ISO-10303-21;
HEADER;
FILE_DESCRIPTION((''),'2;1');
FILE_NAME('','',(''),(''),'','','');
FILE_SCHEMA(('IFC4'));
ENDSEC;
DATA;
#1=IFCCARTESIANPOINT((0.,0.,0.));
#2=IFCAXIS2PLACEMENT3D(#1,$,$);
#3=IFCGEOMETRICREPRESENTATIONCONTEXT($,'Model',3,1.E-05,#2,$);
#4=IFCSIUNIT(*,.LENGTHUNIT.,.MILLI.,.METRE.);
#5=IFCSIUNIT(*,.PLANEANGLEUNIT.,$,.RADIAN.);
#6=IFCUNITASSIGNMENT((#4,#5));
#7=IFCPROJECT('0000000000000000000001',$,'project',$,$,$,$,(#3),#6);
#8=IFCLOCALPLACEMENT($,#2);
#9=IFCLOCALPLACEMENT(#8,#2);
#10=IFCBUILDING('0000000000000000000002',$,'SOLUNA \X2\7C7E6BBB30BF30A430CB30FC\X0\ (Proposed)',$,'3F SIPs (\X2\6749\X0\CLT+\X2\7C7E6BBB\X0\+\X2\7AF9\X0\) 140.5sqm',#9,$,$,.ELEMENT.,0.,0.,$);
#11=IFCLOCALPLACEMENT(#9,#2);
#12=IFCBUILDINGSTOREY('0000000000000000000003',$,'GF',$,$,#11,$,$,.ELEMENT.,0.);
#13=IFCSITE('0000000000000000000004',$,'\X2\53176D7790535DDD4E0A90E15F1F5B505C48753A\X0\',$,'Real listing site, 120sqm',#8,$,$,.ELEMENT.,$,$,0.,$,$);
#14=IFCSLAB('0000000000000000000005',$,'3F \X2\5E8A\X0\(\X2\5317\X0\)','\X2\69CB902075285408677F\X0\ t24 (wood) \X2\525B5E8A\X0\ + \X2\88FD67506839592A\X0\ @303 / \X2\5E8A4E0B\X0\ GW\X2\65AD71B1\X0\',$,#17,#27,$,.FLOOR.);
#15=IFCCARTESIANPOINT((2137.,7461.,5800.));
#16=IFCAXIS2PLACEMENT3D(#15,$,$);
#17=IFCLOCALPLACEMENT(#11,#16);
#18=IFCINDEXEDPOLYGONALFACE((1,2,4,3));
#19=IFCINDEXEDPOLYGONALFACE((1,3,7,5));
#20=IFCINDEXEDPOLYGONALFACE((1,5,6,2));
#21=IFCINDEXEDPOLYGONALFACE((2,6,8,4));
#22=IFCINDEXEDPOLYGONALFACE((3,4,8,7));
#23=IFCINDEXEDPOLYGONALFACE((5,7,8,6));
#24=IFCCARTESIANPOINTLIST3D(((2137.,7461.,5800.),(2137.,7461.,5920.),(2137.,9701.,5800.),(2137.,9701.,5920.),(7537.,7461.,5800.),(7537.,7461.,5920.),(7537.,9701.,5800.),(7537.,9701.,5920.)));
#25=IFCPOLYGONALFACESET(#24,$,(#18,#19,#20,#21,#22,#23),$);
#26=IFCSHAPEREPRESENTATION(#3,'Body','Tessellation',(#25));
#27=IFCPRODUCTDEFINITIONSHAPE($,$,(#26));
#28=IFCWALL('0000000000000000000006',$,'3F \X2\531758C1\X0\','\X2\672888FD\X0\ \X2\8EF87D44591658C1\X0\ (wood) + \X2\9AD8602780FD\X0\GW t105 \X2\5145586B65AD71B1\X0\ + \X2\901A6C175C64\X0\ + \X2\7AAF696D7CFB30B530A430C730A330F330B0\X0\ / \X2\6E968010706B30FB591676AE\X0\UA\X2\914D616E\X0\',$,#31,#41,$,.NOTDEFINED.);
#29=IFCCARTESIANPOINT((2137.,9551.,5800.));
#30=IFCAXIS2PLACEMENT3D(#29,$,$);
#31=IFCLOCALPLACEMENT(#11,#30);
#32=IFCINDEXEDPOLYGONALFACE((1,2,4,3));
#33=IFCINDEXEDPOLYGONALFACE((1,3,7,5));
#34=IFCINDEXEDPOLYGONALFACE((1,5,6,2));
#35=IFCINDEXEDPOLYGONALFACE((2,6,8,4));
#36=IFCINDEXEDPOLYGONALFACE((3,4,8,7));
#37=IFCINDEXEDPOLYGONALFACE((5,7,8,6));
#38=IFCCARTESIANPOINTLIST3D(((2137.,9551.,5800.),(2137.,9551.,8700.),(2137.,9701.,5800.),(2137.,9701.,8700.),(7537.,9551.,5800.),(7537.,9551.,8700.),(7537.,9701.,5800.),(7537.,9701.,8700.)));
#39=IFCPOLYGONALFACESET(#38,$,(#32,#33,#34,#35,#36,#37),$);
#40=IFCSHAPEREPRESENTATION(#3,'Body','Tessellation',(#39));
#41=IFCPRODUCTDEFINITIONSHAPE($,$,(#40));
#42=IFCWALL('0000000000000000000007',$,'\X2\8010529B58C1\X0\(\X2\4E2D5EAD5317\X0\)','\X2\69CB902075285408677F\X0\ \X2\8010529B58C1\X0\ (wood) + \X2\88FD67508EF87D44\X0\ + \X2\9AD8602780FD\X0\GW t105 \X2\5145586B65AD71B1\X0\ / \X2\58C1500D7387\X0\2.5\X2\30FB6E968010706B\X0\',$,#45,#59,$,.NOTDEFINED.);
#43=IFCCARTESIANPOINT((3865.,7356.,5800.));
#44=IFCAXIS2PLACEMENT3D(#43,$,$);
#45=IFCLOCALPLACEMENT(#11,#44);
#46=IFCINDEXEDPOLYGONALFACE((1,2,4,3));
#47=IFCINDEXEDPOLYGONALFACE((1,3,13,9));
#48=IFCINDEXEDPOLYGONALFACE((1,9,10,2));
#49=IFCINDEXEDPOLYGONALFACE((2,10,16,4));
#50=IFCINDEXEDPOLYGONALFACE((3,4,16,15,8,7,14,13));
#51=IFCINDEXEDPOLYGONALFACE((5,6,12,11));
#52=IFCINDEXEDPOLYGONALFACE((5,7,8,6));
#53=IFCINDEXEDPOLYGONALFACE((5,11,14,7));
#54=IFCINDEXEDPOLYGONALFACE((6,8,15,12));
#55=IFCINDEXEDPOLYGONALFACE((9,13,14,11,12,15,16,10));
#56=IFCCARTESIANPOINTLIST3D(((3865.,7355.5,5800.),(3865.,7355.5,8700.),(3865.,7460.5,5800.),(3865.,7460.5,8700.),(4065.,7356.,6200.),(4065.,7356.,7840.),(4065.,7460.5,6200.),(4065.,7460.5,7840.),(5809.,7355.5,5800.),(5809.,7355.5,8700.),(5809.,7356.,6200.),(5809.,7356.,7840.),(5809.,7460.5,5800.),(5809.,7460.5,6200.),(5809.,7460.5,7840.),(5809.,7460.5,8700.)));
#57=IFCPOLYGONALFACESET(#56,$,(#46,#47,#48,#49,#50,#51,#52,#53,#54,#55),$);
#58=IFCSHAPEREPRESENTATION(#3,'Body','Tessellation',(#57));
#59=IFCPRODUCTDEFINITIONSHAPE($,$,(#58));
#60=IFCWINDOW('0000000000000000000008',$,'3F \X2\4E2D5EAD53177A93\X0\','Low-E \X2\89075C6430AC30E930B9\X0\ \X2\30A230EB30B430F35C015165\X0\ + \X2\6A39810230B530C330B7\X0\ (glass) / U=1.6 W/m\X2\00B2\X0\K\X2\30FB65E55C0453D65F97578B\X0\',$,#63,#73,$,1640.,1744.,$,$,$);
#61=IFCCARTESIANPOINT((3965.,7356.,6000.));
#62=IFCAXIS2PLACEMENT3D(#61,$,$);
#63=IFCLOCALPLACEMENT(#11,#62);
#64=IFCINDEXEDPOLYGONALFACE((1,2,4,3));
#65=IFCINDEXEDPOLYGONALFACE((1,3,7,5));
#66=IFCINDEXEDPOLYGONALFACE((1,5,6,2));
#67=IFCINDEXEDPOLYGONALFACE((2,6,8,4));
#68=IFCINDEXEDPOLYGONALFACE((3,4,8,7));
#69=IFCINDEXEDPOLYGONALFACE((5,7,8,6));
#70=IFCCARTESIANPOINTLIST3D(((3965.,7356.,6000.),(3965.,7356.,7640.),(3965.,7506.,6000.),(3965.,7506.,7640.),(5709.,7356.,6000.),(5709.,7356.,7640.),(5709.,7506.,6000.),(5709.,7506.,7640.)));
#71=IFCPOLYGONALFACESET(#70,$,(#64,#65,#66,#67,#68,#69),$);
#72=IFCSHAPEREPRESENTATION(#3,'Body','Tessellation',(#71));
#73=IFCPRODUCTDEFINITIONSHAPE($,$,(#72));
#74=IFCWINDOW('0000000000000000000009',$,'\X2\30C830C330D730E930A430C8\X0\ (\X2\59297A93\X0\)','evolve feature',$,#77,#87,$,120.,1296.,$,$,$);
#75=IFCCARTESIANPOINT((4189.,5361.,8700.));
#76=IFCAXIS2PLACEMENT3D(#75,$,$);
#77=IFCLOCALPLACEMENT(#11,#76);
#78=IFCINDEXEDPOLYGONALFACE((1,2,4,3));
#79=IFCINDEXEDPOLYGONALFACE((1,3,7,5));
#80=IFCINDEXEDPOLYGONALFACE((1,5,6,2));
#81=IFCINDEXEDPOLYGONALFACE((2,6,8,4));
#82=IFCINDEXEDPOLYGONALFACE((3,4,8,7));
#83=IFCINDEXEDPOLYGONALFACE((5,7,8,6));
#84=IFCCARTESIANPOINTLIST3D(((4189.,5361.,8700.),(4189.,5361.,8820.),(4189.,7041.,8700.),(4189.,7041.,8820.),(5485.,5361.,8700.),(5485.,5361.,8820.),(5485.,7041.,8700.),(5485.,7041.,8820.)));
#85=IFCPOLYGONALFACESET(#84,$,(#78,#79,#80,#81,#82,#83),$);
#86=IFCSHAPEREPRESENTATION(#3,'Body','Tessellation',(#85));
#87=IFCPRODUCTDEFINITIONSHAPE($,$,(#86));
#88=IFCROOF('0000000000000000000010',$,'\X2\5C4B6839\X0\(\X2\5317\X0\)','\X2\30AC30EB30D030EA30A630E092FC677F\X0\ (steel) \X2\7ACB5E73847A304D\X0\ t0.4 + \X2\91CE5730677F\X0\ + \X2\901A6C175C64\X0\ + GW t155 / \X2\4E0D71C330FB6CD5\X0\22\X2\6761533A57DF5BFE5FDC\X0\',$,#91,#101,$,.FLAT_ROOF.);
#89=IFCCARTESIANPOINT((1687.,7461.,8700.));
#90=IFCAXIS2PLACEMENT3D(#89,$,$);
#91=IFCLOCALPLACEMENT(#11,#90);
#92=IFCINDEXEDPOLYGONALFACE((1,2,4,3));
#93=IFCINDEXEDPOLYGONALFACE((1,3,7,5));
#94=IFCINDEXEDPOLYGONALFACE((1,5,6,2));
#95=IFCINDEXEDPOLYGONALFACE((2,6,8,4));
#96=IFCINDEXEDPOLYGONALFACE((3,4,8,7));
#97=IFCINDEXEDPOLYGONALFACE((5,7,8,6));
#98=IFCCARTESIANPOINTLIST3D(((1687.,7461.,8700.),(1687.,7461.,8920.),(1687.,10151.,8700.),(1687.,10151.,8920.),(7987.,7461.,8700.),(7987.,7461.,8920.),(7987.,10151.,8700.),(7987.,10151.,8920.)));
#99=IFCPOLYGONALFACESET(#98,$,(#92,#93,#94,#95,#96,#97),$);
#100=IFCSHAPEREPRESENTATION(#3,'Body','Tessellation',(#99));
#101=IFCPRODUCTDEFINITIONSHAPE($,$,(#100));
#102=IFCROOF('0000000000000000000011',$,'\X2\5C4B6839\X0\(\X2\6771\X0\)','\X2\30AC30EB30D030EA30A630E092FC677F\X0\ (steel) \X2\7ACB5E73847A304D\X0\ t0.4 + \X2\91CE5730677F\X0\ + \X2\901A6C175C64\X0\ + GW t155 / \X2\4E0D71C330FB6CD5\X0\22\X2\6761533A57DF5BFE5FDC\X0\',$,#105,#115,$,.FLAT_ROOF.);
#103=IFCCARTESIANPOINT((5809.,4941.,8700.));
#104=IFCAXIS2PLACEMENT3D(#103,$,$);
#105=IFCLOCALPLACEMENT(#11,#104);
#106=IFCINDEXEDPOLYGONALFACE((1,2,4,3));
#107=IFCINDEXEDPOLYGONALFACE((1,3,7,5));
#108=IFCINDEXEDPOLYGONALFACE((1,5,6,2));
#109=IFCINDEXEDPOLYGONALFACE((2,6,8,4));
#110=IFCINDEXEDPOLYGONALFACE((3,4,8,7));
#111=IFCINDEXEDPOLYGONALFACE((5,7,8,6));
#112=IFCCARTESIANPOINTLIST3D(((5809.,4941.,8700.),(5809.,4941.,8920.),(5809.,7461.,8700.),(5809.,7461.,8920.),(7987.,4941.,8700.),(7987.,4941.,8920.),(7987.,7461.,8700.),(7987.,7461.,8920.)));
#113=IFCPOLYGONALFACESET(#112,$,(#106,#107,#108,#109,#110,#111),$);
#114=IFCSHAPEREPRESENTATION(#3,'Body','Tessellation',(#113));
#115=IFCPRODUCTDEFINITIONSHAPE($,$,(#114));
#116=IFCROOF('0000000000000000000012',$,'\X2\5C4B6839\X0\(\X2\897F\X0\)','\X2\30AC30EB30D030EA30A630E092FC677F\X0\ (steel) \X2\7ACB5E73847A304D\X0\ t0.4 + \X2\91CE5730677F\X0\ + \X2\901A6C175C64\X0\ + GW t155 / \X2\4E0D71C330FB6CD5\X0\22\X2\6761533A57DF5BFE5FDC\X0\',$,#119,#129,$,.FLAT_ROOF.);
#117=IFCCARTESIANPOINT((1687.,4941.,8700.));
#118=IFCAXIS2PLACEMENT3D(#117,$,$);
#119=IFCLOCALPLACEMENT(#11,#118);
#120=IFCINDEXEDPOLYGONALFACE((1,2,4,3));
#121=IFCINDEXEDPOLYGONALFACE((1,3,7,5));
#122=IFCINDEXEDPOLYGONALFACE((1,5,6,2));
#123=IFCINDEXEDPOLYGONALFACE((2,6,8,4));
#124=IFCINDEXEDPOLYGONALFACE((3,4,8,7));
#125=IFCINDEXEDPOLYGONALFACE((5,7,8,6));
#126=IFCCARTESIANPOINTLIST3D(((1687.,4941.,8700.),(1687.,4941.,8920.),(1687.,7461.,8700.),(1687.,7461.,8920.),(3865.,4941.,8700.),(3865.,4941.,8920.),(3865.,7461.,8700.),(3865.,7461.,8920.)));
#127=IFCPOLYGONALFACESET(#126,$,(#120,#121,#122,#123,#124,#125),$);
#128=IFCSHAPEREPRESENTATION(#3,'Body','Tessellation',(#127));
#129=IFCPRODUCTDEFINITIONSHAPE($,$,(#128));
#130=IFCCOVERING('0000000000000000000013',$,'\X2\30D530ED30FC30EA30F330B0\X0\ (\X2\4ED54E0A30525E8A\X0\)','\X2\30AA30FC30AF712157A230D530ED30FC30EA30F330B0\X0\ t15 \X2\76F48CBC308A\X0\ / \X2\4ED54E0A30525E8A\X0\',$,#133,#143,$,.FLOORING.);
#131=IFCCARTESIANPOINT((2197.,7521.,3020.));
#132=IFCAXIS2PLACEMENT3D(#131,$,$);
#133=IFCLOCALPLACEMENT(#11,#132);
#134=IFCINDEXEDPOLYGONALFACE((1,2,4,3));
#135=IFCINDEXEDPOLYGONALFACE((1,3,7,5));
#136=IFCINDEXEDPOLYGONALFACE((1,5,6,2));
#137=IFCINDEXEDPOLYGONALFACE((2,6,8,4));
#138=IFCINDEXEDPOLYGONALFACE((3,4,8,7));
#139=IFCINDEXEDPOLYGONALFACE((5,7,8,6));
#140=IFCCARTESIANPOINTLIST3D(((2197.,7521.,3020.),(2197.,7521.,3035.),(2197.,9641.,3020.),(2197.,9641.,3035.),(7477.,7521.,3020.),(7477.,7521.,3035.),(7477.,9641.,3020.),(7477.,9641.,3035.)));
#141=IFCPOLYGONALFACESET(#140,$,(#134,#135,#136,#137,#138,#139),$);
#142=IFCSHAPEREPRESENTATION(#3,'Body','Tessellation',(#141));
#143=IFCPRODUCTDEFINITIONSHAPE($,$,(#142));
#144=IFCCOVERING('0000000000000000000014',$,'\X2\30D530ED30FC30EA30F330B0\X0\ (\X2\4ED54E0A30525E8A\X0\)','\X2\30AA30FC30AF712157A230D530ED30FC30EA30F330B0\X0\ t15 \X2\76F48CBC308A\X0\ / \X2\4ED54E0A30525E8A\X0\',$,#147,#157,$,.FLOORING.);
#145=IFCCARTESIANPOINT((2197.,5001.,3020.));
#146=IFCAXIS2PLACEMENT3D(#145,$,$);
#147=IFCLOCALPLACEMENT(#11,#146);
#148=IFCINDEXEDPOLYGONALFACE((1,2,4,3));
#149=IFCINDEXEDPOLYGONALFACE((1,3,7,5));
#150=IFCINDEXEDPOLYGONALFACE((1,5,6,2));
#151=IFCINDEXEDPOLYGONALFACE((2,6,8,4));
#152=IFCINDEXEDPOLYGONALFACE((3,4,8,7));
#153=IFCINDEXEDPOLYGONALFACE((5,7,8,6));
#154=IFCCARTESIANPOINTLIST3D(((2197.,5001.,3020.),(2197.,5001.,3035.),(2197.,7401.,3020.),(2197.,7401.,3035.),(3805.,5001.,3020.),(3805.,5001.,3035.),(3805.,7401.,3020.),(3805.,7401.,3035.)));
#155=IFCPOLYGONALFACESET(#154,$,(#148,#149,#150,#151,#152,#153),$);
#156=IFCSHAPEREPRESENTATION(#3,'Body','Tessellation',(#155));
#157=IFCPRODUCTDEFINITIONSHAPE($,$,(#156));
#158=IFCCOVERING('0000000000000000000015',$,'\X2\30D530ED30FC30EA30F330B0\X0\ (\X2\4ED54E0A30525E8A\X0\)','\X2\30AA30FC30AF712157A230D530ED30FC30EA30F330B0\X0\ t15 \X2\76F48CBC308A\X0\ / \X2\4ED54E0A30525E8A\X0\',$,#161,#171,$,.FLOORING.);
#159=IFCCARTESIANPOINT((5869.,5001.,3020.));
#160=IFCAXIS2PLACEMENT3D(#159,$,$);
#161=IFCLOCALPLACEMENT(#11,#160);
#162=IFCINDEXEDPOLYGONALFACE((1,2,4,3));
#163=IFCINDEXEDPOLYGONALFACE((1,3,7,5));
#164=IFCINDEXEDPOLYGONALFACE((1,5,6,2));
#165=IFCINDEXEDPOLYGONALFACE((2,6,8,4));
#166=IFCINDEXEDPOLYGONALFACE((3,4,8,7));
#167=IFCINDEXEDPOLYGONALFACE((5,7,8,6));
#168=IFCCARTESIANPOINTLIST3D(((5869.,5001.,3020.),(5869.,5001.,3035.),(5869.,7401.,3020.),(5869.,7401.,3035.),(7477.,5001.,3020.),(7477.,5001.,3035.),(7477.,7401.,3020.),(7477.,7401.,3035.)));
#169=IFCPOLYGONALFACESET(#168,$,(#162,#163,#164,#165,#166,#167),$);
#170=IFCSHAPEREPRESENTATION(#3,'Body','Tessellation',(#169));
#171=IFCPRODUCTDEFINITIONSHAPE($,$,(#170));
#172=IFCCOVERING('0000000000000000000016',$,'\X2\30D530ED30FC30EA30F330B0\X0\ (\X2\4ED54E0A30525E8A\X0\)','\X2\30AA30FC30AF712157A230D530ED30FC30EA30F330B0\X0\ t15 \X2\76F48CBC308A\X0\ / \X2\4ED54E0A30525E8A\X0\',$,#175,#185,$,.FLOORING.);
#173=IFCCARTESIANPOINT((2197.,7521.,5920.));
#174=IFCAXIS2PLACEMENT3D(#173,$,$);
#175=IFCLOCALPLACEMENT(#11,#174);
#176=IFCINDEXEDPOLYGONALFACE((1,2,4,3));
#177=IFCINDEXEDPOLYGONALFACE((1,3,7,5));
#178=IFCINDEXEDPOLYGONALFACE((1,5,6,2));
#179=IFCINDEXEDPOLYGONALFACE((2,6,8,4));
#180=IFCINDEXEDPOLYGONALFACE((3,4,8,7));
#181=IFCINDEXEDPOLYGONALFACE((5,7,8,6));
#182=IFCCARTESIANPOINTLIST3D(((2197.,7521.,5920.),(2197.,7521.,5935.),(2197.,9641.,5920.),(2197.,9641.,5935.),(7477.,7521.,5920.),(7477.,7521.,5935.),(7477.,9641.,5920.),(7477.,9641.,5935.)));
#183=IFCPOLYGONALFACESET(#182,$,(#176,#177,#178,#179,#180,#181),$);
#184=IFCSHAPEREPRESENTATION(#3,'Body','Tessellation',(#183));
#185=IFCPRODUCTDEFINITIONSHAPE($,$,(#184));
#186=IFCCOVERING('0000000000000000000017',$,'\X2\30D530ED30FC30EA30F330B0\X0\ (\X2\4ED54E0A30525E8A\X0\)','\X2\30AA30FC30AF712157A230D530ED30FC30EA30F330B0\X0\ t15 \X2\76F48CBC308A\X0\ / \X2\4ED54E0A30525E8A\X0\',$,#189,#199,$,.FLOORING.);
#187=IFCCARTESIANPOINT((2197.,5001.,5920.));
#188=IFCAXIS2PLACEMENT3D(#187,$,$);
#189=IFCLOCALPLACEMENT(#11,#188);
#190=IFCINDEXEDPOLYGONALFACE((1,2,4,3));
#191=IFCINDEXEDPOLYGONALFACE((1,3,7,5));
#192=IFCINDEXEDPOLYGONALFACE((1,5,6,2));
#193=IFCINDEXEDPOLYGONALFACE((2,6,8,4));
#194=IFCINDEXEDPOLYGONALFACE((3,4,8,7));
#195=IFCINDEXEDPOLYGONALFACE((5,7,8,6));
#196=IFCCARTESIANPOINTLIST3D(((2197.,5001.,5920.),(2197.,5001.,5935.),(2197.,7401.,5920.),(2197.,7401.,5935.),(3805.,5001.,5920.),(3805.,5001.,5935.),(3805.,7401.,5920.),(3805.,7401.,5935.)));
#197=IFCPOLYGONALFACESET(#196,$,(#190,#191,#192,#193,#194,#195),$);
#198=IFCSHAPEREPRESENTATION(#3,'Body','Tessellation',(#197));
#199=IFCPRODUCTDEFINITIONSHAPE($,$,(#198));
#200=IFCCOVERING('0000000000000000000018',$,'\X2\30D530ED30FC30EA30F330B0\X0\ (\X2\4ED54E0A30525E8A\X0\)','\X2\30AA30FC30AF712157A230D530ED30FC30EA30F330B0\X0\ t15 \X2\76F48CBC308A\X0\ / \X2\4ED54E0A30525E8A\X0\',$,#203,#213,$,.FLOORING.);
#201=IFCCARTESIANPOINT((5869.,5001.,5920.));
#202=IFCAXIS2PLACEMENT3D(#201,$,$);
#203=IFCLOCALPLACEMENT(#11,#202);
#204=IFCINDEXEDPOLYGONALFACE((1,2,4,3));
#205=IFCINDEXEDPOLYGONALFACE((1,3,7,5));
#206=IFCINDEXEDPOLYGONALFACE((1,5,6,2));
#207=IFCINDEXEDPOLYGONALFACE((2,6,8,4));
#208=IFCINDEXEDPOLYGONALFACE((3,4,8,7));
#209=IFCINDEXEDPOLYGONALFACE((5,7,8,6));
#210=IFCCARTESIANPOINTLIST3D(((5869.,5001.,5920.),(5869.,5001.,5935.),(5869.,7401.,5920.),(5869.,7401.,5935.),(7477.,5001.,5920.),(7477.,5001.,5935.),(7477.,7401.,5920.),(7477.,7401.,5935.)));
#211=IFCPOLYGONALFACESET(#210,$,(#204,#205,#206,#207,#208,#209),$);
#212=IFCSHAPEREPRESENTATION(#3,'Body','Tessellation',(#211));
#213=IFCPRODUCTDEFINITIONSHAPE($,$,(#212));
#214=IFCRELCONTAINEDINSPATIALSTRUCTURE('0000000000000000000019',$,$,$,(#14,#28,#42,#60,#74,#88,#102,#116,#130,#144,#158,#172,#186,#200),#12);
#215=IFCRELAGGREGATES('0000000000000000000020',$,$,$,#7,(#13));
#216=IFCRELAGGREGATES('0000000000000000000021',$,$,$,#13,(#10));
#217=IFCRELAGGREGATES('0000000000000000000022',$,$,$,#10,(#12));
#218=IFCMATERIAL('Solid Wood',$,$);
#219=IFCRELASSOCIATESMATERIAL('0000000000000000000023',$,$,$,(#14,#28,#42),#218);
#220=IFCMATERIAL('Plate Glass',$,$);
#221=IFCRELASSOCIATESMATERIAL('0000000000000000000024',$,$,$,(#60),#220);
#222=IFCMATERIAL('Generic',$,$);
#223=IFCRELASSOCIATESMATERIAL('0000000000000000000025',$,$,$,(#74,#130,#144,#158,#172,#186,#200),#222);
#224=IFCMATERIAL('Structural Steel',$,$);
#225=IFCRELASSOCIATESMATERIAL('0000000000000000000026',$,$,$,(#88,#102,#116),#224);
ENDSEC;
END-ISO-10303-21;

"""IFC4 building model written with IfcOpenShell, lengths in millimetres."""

from ifc_helpers import new_model, si_unit, frame, frame_2d, origin, place, context, project, spatial, rectangle, extrude, material, element, fill, save


model = new_model("IFC4")

# Units and contexts
model_context = context("Model", 3, precision=1e-05, world=origin())
ifc_project = project(units=[si_unit("LENGTHUNIT", "METRE", prefix="MILLI"), si_unit("PLANEANGLEUNIT", "RADIAN")], contexts=[model_context])

# Site, building, storey
site_placement = place(None, origin())
site = spatial("IfcSite", under=ifc_project, at=site_placement, Name="北海道川上郡弟子屈町", ObjectType="Real listing site, 120sqm", CompositionType="ELEMENT", RefElevation=0.0)
building_placement = place(site_placement, origin())
building = spatial("IfcBuilding", under=site, at=building_placement, Name="SOLUNA 籾殻タイニー (Proposed)", ObjectType="3F SIPs (杉CLT+籾殻+竹) 140.5sqm", CompositionType="ELEMENT", ElevationOfRefHeight=0.0, ElevationOfTerrain=0.0)
storey_placement = place(building_placement, origin())
storey = spatial("IfcBuildingStorey", under=building, at=storey_placement, Name="GF", CompositionType="ELEMENT", Elevation=0.0)

# Slab
ifc_material_1 = material(Name="Solid Wood")
slab_placement = place(storey_placement, frame((2137.0, 7461.0, 5800.0)))
element("IfcSlab", 1, at=slab_placement, inside=storey, material=ifc_material_1, Name="3F 床(北)", Description="構造用合板 t24 (wood) 剛床 + 製材根太 @303 / 床下 GW断熱", PredefinedType="FLOOR", context=model_context, shape_type="SweptSolid", body=[
    extrude(rectangle(XDim=5400.0, YDim=2240.0, at=frame_2d((2700.0, 1120.0))), frame((2137.0, 7461.0, 5800.0)), (0.0, 0.0, 1.0), 120.0),
])

# Wall
wall_1_placement = place(storey_placement, frame((2137.0, 9551.0, 5800.0)))
element("IfcWall", 2, at=wall_1_placement, inside=storey, material=ifc_material_1, Name="3F 北壁", Description="木製 軸組外壁 (wood) + 高性能GW t105 充填断熱 + 通気層 + 窯業系サイディング / 準耐火・外皮UA配慮", PredefinedType="NOTDEFINED", context=model_context, shape_type="SweptSolid", body=[
    extrude(rectangle(XDim=5400.0, YDim=150.0, at=frame_2d((2700.0, 75.0))), frame((2137.0, 9551.0, 5800.0)), (0.0, 0.0, 1.0), 2900.0),
])

# Wall, opening, window
wall_2_placement = place(storey_placement, frame((3865.0, 7356.0, 5800.0)))
wall_2 = element("IfcWall", 3, at=wall_2_placement, inside=storey, material=ifc_material_1, Name="耐力壁(中庭北)", Description="構造用合板 耐力壁 (wood) + 製材軸組 + 高性能GW t105 充填断熱 / 壁倍率2.5・準耐火", PredefinedType="NOTDEFINED", context=model_context, shape_type="SweptSolid", body=[
    extrude(rectangle(XDim=1944.0, YDim=105.0, at=frame_2d((972.0, 52.0))), frame((3865.0, 7356.0, 5800.0)), (0.0, 0.0, 1.0), 2900.0),
])
opening_placement = place(storey_placement, frame((3965.0, 7356.0, 6000.0)))
opening = element("IfcOpeningElement", 4, at=opening_placement, cuts=wall_2, PredefinedType="NOTDEFINED", context=model_context, shape_type="SweptSolid", body=[
    extrude(rectangle(XDim=1744.0, YDim=150.0, at=frame_2d((872.0, 75.0))), frame((3965.0, 7356.0, 6000.0)), (0.0, 0.0, 1.0), 1640.0),
])
ifc_material_2 = material(Name="Plate Glass")
window_1_placement = place(storey_placement, frame((3965.0, 7356.0, 6000.0)))
window_1 = element("IfcWindow", 5, at=window_1_placement, inside=storey, material=ifc_material_2, Name="3F 中庭北窓", Description="Low-E 複層ガラス アルゴン封入 + 樹脂サッシ (glass) / U=1.6 W/m²K・日射取得型", OverallHeight=1640.0, OverallWidth=1744.0, context=model_context, shape_type="SweptSolid", body=[
    extrude(rectangle(XDim=1744.0, YDim=150.0, at=frame_2d((872.0, 75.0))), frame((3965.0, 7356.0, 6000.0)), (0.0, 0.0, 1.0), 1640.0),
])
fill(opening, window_1)

# Window
ifc_material_3 = material(Name="Generic")
window_2_placement = place(storey_placement, frame((4189.0, 5361.0, 8700.0)))
element("IfcWindow", 6, at=window_2_placement, inside=storey, material=ifc_material_3, Name="トップライト (天窓)", Description="evolve feature", OverallHeight=120.0, OverallWidth=1296.0, context=model_context, shape_type="SweptSolid", body=[
    extrude(rectangle(XDim=1296.0, YDim=1680.0, at=frame_2d((648.0, 840.0))), frame((4189.0, 5361.0, 8700.0)), (0.0, 0.0, 1.0), 120.0),
])

# Roofs
ifc_material_4 = material(Name="Structural Steel")
roof_1_placement = place(storey_placement, frame((1687.0, 7461.0, 8700.0)))
element("IfcRoof", 7, at=roof_1_placement, inside=storey, material=ifc_material_4, Name="屋根(北)", Description="ガルバリウム鋼板 (steel) 立平葺き t0.4 + 野地板 + 通気層 + GW t155 / 不燃・法22条区域対応", PredefinedType="FLAT_ROOF", context=model_context, shape_type="SweptSolid", body=[
    extrude(rectangle(XDim=6300.0, YDim=2690.0, at=frame_2d((3150.0, 1345.0))), frame((1687.0, 7461.0, 8700.0)), (0.0, 0.0, 1.0), 220.0),
])
roof_2_placement = place(storey_placement, frame((5809.0, 4941.0, 8700.0)))
element("IfcRoof", 8, at=roof_2_placement, inside=storey, material=ifc_material_4, Name="屋根(東)", Description="ガルバリウム鋼板 (steel) 立平葺き t0.4 + 野地板 + 通気層 + GW t155 / 不燃・法22条区域対応", PredefinedType="FLAT_ROOF", context=model_context, shape_type="SweptSolid", body=[
    extrude(rectangle(XDim=2178.0, YDim=2520.0, at=frame_2d((1089.0, 1260.0))), frame((5809.0, 4941.0, 8700.0)), (0.0, 0.0, 1.0), 220.0),
])
roof_3_placement = place(storey_placement, frame((1687.0, 4941.0, 8700.0)))
element("IfcRoof", 9, at=roof_3_placement, inside=storey, material=ifc_material_4, Name="屋根(西)", Description="ガルバリウム鋼板 (steel) 立平葺き t0.4 + 野地板 + 通気層 + GW t155 / 不燃・法22条区域対応", PredefinedType="FLAT_ROOF", context=model_context, shape_type="SweptSolid", body=[
    extrude(rectangle(XDim=2178.0, YDim=2520.0, at=frame_2d((1089.0, 1260.0))), frame((1687.0, 4941.0, 8700.0)), (0.0, 0.0, 1.0), 220.0),
])

# Coverings
covering_1_placement = place(storey_placement, frame((2197.0, 7521.0, 3020.0)))
element("IfcCovering", 10, at=covering_1_placement, inside=storey, material=ifc_material_3, Name="フローリング (仕上げ床)", Description="オーク無垢フローリング t15 直貼り / 仕上げ床", PredefinedType="FLOORING", context=model_context, shape_type="SweptSolid", body=[
    extrude(rectangle(XDim=5280.0, YDim=2120.0, at=frame_2d((2640.0, 1060.0))), frame((2197.0, 7521.0, 3020.0)), (0.0, 0.0, 1.0), 15.0),
])
covering_2_placement = place(storey_placement, frame((2197.0, 5001.0, 3020.0)))
element("IfcCovering", 11, at=covering_2_placement, inside=storey, material=ifc_material_3, Name="フローリング (仕上げ床)", Description="オーク無垢フローリング t15 直貼り / 仕上げ床", PredefinedType="FLOORING", context=model_context, shape_type="SweptSolid", body=[
    extrude(rectangle(XDim=1608.0, YDim=2400.0, at=frame_2d((804.0, 1200.0))), frame((2197.0, 5001.0, 3020.0)), (0.0, 0.0, 1.0), 15.0),
])
covering_3_placement = place(storey_placement, frame((5869.0, 5001.0, 3020.0)))
element("IfcCovering", 12, at=covering_3_placement, inside=storey, material=ifc_material_3, Name="フローリング (仕上げ床)", Description="オーク無垢フローリング t15 直貼り / 仕上げ床", PredefinedType="FLOORING", context=model_context, shape_type="SweptSolid", body=[
    extrude(rectangle(XDim=1608.0, YDim=2400.0, at=frame_2d((804.0, 1200.0))), frame((5869.0, 5001.0, 3020.0)), (0.0, 0.0, 1.0), 15.0),
])
covering_4_placement = place(storey_placement, frame((2197.0, 7521.0, 5920.0)))
element("IfcCovering", 13, at=covering_4_placement, inside=storey, material=ifc_material_3, Name="フローリング (仕上げ床)", Description="オーク無垢フローリング t15 直貼り / 仕上げ床", PredefinedType="FLOORING", context=model_context, shape_type="SweptSolid", body=[
    extrude(rectangle(XDim=5280.0, YDim=2120.0, at=frame_2d((2640.0, 1060.0))), frame((2197.0, 7521.0, 5920.0)), (0.0, 0.0, 1.0), 15.0),
])
covering_5_placement = place(storey_placement, frame((2197.0, 5001.0, 5920.0)))
element("IfcCovering", 14, at=covering_5_placement, inside=storey, material=ifc_material_3, Name="フローリング (仕上げ床)", Description="オーク無垢フローリング t15 直貼り / 仕上げ床", PredefinedType="FLOORING", context=model_context, shape_type="SweptSolid", body=[
    extrude(rectangle(XDim=1608.0, YDim=2400.0, at=frame_2d((804.0, 1200.0))), frame((2197.0, 5001.0, 5920.0)), (0.0, 0.0, 1.0), 15.0),
])
covering_6_placement = place(storey_placement, frame((5869.0, 5001.0, 5920.0)))
element("IfcCovering", 15, at=covering_6_placement, inside=storey, material=ifc_material_3, Name="フローリング (仕上げ床)", Description="オーク無垢フローリング t15 直貼り / 仕上げ床", PredefinedType="FLOORING", context=model_context, shape_type="SweptSolid", body=[
    extrude(rectangle(XDim=1608.0, YDim=2400.0, at=frame_2d((804.0, 1200.0))), frame((5869.0, 5001.0, 5920.0)), (0.0, 0.0, 1.0), 15.0),
])

save(model, "model.ifc")
